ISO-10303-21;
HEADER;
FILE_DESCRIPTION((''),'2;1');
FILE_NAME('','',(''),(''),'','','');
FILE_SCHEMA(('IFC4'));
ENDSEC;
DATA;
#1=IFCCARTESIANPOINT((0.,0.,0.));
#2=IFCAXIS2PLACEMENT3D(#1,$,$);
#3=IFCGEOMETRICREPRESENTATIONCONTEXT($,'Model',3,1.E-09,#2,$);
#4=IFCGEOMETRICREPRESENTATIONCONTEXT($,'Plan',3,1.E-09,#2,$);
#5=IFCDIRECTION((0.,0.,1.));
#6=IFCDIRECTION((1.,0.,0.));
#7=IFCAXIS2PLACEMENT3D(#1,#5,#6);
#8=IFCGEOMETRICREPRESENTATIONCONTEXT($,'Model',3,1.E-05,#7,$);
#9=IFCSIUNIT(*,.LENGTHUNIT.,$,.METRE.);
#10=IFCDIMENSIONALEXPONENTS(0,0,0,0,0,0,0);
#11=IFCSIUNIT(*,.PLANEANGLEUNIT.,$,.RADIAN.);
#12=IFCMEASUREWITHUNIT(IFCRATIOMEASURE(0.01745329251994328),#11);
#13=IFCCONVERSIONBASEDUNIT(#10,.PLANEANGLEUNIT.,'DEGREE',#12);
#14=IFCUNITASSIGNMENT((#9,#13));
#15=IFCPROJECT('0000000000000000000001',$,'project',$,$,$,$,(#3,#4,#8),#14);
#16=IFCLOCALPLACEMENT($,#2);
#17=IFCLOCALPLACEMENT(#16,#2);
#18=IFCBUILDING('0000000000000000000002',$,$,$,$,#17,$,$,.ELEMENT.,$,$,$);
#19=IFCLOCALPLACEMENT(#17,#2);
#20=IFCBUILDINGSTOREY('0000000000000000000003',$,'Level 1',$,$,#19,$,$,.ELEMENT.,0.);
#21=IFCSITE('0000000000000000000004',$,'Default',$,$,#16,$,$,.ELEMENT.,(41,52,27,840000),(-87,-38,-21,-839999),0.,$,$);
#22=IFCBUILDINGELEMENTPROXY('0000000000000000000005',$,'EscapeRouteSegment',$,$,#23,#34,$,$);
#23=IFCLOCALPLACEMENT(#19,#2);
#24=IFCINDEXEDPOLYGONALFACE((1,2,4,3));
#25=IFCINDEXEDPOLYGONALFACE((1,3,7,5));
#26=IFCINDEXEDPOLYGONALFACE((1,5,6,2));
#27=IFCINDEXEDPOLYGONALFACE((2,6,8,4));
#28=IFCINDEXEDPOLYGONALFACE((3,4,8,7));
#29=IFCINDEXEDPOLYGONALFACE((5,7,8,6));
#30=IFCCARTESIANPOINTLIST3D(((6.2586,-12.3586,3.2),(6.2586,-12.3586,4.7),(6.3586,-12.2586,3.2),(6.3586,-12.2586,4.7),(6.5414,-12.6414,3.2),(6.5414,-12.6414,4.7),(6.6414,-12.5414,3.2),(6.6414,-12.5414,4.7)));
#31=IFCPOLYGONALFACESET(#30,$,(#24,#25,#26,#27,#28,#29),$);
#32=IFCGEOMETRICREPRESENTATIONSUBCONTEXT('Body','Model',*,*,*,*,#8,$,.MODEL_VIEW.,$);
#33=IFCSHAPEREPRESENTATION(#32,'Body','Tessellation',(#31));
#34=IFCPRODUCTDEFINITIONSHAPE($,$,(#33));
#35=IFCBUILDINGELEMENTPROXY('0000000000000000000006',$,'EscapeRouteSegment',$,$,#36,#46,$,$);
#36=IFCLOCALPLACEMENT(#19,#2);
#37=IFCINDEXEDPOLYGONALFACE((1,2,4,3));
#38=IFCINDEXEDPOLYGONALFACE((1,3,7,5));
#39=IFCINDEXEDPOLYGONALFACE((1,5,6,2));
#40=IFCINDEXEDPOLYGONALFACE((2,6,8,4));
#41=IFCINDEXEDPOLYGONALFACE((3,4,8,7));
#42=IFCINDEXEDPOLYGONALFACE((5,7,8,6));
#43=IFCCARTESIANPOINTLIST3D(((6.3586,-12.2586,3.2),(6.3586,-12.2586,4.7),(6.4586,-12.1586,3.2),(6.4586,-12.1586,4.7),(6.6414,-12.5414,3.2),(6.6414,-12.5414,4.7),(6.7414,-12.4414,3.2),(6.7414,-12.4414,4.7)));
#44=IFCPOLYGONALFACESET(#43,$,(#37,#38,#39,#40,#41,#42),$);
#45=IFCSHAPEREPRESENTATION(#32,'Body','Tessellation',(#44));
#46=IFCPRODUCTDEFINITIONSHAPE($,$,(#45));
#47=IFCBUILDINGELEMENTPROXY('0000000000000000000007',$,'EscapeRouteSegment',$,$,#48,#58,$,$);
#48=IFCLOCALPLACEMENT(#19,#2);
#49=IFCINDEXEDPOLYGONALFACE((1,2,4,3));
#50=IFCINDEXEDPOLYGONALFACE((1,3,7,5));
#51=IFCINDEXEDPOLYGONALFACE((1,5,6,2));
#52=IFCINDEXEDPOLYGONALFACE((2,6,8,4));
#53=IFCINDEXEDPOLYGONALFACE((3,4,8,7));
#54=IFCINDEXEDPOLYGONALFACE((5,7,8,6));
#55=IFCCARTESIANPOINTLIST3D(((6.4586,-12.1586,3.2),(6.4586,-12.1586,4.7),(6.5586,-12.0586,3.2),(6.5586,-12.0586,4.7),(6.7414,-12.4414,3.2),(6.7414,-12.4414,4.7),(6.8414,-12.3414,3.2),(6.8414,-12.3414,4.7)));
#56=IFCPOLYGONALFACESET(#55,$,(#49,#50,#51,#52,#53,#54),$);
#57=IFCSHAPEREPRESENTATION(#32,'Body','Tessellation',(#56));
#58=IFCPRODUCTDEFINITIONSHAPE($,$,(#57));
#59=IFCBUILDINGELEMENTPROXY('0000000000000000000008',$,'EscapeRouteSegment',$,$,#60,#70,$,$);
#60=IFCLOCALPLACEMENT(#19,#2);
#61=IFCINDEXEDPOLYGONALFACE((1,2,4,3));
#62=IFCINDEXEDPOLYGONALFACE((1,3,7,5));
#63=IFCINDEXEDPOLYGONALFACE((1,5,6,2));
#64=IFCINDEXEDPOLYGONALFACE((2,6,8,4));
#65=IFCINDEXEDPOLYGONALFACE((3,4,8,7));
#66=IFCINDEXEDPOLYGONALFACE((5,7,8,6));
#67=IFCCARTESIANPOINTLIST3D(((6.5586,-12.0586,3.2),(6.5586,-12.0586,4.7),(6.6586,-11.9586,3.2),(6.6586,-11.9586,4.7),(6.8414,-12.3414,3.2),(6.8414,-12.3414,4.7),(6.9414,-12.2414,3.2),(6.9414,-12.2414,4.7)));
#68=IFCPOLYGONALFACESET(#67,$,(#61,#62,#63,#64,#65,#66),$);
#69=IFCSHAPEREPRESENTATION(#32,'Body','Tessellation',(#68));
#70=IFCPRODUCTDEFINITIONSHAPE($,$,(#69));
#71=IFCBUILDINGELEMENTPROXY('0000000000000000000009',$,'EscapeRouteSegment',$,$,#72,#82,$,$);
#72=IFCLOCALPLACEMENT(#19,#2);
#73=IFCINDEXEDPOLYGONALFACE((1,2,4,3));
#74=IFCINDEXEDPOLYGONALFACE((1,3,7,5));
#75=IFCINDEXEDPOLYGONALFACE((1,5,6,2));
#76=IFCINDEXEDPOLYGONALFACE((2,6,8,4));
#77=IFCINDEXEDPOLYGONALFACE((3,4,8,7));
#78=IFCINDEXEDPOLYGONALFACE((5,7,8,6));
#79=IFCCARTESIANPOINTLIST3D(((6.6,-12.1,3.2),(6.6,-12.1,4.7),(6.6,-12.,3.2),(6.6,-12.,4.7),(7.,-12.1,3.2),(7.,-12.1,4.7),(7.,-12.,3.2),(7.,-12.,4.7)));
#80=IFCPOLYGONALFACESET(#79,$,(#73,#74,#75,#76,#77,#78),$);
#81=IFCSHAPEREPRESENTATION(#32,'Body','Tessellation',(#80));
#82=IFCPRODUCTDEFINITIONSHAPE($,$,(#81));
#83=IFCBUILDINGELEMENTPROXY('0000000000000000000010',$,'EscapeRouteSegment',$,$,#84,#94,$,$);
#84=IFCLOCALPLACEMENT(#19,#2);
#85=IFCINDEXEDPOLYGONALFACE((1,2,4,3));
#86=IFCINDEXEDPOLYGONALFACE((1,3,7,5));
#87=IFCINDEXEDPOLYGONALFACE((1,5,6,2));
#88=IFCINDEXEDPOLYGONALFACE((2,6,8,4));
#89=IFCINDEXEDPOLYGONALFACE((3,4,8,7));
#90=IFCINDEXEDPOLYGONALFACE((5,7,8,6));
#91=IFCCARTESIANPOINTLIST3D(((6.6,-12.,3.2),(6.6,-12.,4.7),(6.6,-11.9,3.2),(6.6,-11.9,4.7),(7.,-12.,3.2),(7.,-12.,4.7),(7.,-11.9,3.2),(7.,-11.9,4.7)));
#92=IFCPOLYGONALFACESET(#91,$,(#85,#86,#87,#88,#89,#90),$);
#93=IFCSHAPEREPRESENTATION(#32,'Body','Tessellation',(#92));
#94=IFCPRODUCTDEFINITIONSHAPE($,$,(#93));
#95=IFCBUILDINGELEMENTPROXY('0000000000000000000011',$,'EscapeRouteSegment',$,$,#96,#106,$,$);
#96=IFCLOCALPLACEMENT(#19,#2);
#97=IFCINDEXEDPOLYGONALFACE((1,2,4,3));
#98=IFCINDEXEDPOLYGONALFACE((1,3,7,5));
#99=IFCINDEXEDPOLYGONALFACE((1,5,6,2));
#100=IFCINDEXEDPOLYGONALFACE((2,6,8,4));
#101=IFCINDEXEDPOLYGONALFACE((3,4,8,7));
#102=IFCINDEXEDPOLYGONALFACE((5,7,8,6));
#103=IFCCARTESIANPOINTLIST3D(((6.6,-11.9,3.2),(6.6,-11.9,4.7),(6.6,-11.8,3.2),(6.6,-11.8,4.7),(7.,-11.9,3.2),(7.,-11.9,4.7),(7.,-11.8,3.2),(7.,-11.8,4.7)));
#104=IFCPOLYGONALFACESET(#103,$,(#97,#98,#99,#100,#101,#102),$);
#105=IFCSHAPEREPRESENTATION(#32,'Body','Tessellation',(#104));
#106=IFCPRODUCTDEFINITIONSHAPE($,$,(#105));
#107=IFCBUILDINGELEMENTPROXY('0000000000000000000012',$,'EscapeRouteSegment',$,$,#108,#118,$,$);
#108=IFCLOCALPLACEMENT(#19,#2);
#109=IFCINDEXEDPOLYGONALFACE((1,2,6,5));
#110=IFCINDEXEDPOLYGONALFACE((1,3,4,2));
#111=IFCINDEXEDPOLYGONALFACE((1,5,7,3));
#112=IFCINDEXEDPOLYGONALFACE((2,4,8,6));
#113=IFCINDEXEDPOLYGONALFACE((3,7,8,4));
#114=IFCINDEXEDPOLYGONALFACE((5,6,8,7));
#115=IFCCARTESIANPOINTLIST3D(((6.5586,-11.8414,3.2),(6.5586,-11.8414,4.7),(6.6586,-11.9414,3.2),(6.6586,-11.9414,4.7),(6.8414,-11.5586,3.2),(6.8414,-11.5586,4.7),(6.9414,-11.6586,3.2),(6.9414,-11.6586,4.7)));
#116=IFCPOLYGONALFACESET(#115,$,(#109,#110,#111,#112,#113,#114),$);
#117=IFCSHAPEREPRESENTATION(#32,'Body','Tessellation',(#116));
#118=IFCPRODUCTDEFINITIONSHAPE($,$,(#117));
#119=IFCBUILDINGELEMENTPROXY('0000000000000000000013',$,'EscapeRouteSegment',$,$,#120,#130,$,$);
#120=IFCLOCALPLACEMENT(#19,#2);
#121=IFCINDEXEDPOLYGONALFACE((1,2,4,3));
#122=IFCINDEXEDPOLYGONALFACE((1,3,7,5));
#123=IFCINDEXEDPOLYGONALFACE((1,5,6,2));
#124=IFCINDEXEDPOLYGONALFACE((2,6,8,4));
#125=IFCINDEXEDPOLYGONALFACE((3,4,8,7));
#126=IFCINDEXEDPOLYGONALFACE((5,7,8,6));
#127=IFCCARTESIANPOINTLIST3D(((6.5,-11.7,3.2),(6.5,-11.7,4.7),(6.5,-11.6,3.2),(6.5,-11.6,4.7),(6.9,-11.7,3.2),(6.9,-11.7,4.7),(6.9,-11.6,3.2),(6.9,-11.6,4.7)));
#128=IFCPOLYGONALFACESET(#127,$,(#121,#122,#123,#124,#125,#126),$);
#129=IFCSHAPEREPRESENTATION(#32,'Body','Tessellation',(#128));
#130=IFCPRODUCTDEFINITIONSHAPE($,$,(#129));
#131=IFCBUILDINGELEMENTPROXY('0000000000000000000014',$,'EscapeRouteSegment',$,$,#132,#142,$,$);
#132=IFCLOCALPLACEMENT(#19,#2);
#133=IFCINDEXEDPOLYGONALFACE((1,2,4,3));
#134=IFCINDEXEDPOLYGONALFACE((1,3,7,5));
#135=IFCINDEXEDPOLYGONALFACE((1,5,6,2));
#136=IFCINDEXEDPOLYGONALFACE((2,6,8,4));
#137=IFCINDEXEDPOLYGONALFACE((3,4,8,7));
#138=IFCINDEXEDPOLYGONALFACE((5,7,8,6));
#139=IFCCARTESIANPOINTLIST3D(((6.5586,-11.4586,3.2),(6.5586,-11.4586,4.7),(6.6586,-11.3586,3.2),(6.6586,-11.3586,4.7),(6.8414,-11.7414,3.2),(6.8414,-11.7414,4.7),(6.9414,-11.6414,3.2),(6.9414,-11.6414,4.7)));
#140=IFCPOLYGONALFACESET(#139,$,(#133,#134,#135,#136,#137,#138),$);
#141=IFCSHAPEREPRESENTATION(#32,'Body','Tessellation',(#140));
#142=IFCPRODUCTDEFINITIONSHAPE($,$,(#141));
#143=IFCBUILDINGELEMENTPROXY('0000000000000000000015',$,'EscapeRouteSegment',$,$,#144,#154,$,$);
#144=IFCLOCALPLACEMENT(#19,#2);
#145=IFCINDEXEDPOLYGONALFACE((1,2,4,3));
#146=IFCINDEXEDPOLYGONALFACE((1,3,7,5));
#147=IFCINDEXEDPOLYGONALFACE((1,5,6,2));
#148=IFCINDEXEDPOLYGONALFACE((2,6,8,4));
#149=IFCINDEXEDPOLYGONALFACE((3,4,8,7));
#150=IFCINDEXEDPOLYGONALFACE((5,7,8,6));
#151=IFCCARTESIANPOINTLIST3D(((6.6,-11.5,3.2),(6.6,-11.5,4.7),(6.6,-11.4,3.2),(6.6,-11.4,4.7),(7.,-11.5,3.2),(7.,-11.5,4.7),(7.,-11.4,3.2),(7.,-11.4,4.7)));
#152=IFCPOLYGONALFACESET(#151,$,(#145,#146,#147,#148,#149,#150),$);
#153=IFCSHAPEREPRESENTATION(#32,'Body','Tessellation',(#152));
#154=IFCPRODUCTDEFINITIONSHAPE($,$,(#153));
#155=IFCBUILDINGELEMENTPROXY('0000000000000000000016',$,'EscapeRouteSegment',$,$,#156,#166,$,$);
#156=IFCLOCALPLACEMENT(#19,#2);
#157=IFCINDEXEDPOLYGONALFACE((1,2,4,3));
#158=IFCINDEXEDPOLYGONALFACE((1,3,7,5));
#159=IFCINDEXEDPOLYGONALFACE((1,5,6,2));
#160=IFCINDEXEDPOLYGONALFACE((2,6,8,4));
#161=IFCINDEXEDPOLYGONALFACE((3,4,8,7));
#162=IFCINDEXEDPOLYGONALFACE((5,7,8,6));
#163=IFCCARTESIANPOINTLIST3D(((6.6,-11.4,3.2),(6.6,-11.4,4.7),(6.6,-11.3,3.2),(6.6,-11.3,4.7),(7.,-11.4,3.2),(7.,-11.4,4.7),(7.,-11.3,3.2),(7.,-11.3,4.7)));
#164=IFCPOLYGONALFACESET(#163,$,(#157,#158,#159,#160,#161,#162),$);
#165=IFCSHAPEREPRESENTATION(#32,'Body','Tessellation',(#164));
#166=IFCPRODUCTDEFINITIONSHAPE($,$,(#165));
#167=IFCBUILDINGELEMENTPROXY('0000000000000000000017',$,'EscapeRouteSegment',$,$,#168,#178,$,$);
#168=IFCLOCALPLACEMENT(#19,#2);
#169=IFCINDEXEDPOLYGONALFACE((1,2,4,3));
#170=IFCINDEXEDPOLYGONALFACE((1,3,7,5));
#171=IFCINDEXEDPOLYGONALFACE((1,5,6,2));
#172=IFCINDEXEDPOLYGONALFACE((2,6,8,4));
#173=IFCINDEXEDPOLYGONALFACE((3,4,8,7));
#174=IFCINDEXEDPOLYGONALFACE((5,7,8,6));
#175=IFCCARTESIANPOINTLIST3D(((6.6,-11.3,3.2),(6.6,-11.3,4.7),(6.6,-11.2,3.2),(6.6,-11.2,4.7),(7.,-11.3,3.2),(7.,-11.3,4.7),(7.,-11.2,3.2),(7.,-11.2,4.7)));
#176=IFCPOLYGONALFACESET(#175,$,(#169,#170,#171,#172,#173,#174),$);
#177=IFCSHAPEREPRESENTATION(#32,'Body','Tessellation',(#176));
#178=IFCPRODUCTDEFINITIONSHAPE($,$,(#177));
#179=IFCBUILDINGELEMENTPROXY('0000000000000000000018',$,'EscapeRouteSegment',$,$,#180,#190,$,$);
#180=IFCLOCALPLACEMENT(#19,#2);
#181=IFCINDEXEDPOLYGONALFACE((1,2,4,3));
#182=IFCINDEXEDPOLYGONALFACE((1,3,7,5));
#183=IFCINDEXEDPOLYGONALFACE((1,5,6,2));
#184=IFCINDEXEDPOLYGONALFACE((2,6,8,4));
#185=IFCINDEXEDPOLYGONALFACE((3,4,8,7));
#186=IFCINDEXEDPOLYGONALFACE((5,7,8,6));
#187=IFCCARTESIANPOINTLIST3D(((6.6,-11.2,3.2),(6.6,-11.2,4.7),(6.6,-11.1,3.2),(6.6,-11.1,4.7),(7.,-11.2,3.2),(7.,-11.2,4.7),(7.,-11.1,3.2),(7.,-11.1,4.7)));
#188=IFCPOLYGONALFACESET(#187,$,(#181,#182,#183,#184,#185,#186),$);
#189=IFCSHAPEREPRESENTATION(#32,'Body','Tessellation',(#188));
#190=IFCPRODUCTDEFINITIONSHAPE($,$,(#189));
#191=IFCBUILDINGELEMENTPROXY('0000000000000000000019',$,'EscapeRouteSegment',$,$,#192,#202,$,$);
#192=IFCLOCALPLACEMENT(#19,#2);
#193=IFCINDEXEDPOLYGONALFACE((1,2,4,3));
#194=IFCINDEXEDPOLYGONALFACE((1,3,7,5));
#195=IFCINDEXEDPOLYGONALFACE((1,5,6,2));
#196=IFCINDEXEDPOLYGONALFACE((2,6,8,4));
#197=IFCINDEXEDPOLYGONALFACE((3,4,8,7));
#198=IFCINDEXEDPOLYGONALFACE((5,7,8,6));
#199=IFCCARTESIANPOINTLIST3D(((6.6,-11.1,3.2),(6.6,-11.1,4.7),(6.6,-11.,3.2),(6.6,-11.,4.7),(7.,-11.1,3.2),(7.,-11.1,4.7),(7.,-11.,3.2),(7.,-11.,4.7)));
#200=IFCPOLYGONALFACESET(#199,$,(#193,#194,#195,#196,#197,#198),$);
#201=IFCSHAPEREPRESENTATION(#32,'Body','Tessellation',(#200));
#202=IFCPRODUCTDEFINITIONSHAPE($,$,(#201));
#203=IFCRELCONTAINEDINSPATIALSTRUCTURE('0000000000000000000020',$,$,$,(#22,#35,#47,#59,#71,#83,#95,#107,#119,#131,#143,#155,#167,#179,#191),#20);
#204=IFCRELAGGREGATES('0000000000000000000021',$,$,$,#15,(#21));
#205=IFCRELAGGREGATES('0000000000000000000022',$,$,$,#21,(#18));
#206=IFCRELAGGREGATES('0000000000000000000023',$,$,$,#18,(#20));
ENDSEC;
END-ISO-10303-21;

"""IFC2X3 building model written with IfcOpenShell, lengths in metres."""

from ifc_helpers import new_model, entity, si_unit, converted_unit, frame, origin, origin_with_axes, place, context, subcontext, project, spatial, polyline, outline, extrude, element, save


model = new_model("IFC2X3")

# Units and contexts
model_context_1 = context("Model", 3, precision=1e-09, world=origin())
plan_context = context("Plan", 3, precision=1e-09, world=origin())
model_context_2 = context("Model", 3, precision=1e-05, world=origin_with_axes())
body_context = subcontext(model_context_2, "Body", "Model", "MODEL_VIEW")
ifc_project = project(units=[si_unit("LENGTHUNIT", "METRE"), converted_unit("PLANEANGLEUNIT", "DEGREE", entity("IfcRatioMeasure", 0.01745329251994328), si_unit("PLANEANGLEUNIT", "RADIAN"), dimensions=[0, 0, 0, 0, 0, 0, 0])], contexts=[model_context_1, plan_context, model_context_2])

# Site, building, storey
site_placement = place(None, origin())
site = spatial("IfcSite", under=ifc_project, at=site_placement, Name="Default", CompositionType="ELEMENT", RefLatitude=(41, 52, 27, 840000), RefLongitude=(-87, -38, -21, -839999), RefElevation=0.0)
building_placement = place(site_placement, origin())
building = spatial("IfcBuilding", under=site, at=building_placement, CompositionType="ELEMENT")
storey_placement = place(building_placement, origin())
storey = spatial("IfcBuildingStorey", under=building, at=storey_placement, Name="Level 1", CompositionType="ELEMENT", Elevation=0.0)

# Building element proxies
proxy_1_placement = place(storey_placement, frame((6.4, -12.5, 3.2), z_axis=(0.0, 0.0, 1.0), x_axis=(0.707105, 0.707108, 0.0)))
element("IfcBuildingElementProxy", 1, at=proxy_1_placement, inside=storey, Name="EscapeRouteSegment", context=body_context, shape_type="SweptSolid", body=[
    extrude(outline(polyline([(0.0, -0.2), (0.0, 0.2), (0.1414, 0.2), (0.1414, -0.2), (0.0, -0.2)])), origin_with_axes(), (0.0, 0.0, 1.0), 1.5),
])
proxy_2_placement = place(storey_placement, frame((6.5, -12.4, 3.2), z_axis=(0.0, 0.0, 1.0), x_axis=(0.707108, 0.707105, 0.0)))
element("IfcBuildingElementProxy", 2, at=proxy_2_placement, inside=storey, Name="EscapeRouteSegment", context=body_context, shape_type="SweptSolid", body=[
    extrude(outline(polyline([(0.0, -0.2), (0.0, 0.2), (0.1414, 0.2), (0.1414, -0.2), (0.0, -0.2)])), origin_with_axes(), (0.0, 0.0, 1.0), 1.5),
])
proxy_3_placement = place(storey_placement, frame((6.6, -12.3, 3.2), z_axis=(0.0, 0.0, 1.0), x_axis=(0.707105, 0.707108, 0.0)))
element("IfcBuildingElementProxy", 3, at=proxy_3_placement, inside=storey, Name="EscapeRouteSegment", context=body_context, shape_type="SweptSolid", body=[
    extrude(outline(polyline([(0.0, -0.2), (0.0, 0.2), (0.1414, 0.2), (0.1414, -0.2), (0.0, -0.2)])), origin_with_axes(), (0.0, 0.0, 1.0), 1.5),
])
proxy_4_placement = place(storey_placement, frame((6.7, -12.2, 3.2), z_axis=(0.0, 0.0, 1.0), x_axis=(0.70711, 0.707104, 0.0)))
element("IfcBuildingElementProxy", 4, at=proxy_4_placement, inside=storey, Name="EscapeRouteSegment", context=body_context, shape_type="SweptSolid", body=[
    extrude(outline(polyline([(0.0, -0.2), (0.0, 0.2), (0.1414, 0.2), (0.1414, -0.2), (0.0, -0.2)])), origin_with_axes(), (0.0, 0.0, 1.0), 1.5),
])
for number, where, z_axis, x_axis, name in (
    (5, (6.8, -12.1, 3.2), (0.0, 0.0, 1.0), (0.0, 1.0, 0.0), "EscapeRouteSegment"),
    (6, (6.8, -12.0, 3.2), (0.0, 0.0, 1.0), (0.0, 1.0, 0.0), "EscapeRouteSegment"),
):
    element("IfcBuildingElementProxy", number, at=place(storey_placement, frame(where, z_axis=z_axis, x_axis=x_axis)), inside=storey, Name=name, context=body_context, shape_type="SweptSolid", body=[
        extrude(outline(polyline([(0.0, -0.2), (0.0, 0.2), (0.1, 0.2), (0.1, -0.2), (0.0, -0.2)])), origin_with_axes(), (0.0, 0.0, 1.0), 1.5),
    ])
proxy_5_placement = place(storey_placement, frame((6.8, -11.9, 3.2), z_axis=(0.0, 0.0, 1.0), x_axis=(0.0, 1.0, 0.0)))
element("IfcBuildingElementProxy", 7, at=proxy_5_placement, inside=storey, Name="EscapeRouteSegment", context=body_context, shape_type="SweptSolid", body=[
    extrude(outline(polyline([(0.0, -0.2), (0.0, 0.2), (0.1, 0.2), (0.1, -0.2), (0.0, -0.2)])), origin_with_axes(), (0.0, 0.0, 1.0), 1.5),
])
proxy_6_placement = place(storey_placement, frame((6.8, -11.8, 3.2), z_axis=(0.0, 0.0, 1.0), x_axis=(-0.707107, 0.707107, 0.0)))
element("IfcBuildingElementProxy", 8, at=proxy_6_placement, inside=storey, Name="EscapeRouteSegment", context=body_context, shape_type="SweptSolid", body=[
    extrude(outline(polyline([(0.0, -0.2), (0.0, 0.2), (0.1414, 0.2), (0.1414, -0.2), (0.0, -0.2)])), origin_with_axes(), (0.0, 0.0, 1.0), 1.5),
])
proxy_7_placement = place(storey_placement, frame((6.7, -11.7, 3.2), z_axis=(0.0, 0.0, 1.0), x_axis=(0.0, 1.0, 0.0)))
element("IfcBuildingElementProxy", 9, at=proxy_7_placement, inside=storey, Name="EscapeRouteSegment", context=body_context, shape_type="SweptSolid", body=[
    extrude(outline(polyline([(0.0, -0.2), (0.0, 0.2), (0.1, 0.2), (0.1, -0.2), (0.0, -0.2)])), origin_with_axes(), (0.0, 0.0, 1.0), 1.5),
])
proxy_8_placement = place(storey_placement, frame((6.7, -11.6, 3.2), z_axis=(0.0, 0.0, 1.0), x_axis=(0.707107, 0.707107, 0.0)))
element("IfcBuildingElementProxy", 10, at=proxy_8_placement, inside=storey, Name="EscapeRouteSegment", context=body_context, shape_type="SweptSolid", body=[
    extrude(outline(polyline([(0.0, -0.2), (0.0, 0.2), (0.1414, 0.2), (0.1414, -0.2), (0.0, -0.2)])), origin_with_axes(), (0.0, 0.0, 1.0), 1.5),
])
proxy_9_placement = place(storey_placement, frame((6.8, -11.5, 3.2), z_axis=(0.0, 0.0, 1.0), x_axis=(0.0, 1.0, 0.0)))
element("IfcBuildingElementProxy", 11, at=proxy_9_placement, inside=storey, Name="EscapeRouteSegment", context=body_context, shape_type="SweptSolid", body=[
    extrude(outline(polyline([(0.0, -0.2), (0.0, 0.2), (0.1, 0.2), (0.1, -0.2), (0.0, -0.2)])), origin_with_axes(), (0.0, 0.0, 1.0), 1.5),
])
proxy_10_placement = place(storey_placement, frame((6.8, -11.4, 3.2), z_axis=(0.0, 0.0, 1.0), x_axis=(0.0, 1.0, 0.0)))
element("IfcBuildingElementProxy", 12, at=proxy_10_placement, inside=storey, Name="EscapeRouteSegment", context=body_context, shape_type="SweptSolid", body=[
    extrude(outline(polyline([(0.0, -0.2), (0.0, 0.2), (0.1, 0.2), (0.1, -0.2), (0.0, -0.2)])), origin_with_axes(), (0.0, 0.0, 1.0), 1.5),
])
proxy_11_placement = place(storey_placement, frame((6.8, -11.3, 3.2), z_axis=(0.0, 0.0, 1.0), x_axis=(0.0, 1.0, 0.0)))
element("IfcBuildingElementProxy", 13, at=proxy_11_placement, inside=storey, Name="EscapeRouteSegment", context=body_context, shape_type="SweptSolid", body=[
    extrude(outline(polyline([(0.0, -0.2), (0.0, 0.2), (0.1, 0.2), (0.1, -0.2), (0.0, -0.2)])), origin_with_axes(), (0.0, 0.0, 1.0), 1.5),
])
proxy_12_placement = place(storey_placement, frame((6.8, -11.2, 3.2), z_axis=(0.0, 0.0, 1.0), x_axis=(0.0, 1.0, 0.0)))
element("IfcBuildingElementProxy", 14, at=proxy_12_placement, inside=storey, Name="EscapeRouteSegment", context=body_context, shape_type="SweptSolid", body=[
    extrude(outline(polyline([(0.0, -0.2), (0.0, 0.2), (0.1, 0.2), (0.1, -0.2), (0.0, -0.2)])), origin_with_axes(), (0.0, 0.0, 1.0), 1.5),
])
for number, where, z_axis, x_axis, name in (
    (15, (6.8, -11.1, 3.2), (0.0, 0.0, 1.0), (0.0, 1.0, 0.0), "EscapeRouteSegment"),
):
    element("IfcBuildingElementProxy", number, at=place(storey_placement, frame(where, z_axis=z_axis, x_axis=x_axis)), inside=storey, Name=name, context=body_context, shape_type="SweptSolid", body=[
        extrude(outline(polyline([(0.0, -0.2), (0.0, 0.2), (0.1, 0.2), (0.1, -0.2), (0.0, -0.2)])), origin_with_axes(), (0.0, 0.0, 1.0), 1.5),
    ])

save(model, "model.ifc")
